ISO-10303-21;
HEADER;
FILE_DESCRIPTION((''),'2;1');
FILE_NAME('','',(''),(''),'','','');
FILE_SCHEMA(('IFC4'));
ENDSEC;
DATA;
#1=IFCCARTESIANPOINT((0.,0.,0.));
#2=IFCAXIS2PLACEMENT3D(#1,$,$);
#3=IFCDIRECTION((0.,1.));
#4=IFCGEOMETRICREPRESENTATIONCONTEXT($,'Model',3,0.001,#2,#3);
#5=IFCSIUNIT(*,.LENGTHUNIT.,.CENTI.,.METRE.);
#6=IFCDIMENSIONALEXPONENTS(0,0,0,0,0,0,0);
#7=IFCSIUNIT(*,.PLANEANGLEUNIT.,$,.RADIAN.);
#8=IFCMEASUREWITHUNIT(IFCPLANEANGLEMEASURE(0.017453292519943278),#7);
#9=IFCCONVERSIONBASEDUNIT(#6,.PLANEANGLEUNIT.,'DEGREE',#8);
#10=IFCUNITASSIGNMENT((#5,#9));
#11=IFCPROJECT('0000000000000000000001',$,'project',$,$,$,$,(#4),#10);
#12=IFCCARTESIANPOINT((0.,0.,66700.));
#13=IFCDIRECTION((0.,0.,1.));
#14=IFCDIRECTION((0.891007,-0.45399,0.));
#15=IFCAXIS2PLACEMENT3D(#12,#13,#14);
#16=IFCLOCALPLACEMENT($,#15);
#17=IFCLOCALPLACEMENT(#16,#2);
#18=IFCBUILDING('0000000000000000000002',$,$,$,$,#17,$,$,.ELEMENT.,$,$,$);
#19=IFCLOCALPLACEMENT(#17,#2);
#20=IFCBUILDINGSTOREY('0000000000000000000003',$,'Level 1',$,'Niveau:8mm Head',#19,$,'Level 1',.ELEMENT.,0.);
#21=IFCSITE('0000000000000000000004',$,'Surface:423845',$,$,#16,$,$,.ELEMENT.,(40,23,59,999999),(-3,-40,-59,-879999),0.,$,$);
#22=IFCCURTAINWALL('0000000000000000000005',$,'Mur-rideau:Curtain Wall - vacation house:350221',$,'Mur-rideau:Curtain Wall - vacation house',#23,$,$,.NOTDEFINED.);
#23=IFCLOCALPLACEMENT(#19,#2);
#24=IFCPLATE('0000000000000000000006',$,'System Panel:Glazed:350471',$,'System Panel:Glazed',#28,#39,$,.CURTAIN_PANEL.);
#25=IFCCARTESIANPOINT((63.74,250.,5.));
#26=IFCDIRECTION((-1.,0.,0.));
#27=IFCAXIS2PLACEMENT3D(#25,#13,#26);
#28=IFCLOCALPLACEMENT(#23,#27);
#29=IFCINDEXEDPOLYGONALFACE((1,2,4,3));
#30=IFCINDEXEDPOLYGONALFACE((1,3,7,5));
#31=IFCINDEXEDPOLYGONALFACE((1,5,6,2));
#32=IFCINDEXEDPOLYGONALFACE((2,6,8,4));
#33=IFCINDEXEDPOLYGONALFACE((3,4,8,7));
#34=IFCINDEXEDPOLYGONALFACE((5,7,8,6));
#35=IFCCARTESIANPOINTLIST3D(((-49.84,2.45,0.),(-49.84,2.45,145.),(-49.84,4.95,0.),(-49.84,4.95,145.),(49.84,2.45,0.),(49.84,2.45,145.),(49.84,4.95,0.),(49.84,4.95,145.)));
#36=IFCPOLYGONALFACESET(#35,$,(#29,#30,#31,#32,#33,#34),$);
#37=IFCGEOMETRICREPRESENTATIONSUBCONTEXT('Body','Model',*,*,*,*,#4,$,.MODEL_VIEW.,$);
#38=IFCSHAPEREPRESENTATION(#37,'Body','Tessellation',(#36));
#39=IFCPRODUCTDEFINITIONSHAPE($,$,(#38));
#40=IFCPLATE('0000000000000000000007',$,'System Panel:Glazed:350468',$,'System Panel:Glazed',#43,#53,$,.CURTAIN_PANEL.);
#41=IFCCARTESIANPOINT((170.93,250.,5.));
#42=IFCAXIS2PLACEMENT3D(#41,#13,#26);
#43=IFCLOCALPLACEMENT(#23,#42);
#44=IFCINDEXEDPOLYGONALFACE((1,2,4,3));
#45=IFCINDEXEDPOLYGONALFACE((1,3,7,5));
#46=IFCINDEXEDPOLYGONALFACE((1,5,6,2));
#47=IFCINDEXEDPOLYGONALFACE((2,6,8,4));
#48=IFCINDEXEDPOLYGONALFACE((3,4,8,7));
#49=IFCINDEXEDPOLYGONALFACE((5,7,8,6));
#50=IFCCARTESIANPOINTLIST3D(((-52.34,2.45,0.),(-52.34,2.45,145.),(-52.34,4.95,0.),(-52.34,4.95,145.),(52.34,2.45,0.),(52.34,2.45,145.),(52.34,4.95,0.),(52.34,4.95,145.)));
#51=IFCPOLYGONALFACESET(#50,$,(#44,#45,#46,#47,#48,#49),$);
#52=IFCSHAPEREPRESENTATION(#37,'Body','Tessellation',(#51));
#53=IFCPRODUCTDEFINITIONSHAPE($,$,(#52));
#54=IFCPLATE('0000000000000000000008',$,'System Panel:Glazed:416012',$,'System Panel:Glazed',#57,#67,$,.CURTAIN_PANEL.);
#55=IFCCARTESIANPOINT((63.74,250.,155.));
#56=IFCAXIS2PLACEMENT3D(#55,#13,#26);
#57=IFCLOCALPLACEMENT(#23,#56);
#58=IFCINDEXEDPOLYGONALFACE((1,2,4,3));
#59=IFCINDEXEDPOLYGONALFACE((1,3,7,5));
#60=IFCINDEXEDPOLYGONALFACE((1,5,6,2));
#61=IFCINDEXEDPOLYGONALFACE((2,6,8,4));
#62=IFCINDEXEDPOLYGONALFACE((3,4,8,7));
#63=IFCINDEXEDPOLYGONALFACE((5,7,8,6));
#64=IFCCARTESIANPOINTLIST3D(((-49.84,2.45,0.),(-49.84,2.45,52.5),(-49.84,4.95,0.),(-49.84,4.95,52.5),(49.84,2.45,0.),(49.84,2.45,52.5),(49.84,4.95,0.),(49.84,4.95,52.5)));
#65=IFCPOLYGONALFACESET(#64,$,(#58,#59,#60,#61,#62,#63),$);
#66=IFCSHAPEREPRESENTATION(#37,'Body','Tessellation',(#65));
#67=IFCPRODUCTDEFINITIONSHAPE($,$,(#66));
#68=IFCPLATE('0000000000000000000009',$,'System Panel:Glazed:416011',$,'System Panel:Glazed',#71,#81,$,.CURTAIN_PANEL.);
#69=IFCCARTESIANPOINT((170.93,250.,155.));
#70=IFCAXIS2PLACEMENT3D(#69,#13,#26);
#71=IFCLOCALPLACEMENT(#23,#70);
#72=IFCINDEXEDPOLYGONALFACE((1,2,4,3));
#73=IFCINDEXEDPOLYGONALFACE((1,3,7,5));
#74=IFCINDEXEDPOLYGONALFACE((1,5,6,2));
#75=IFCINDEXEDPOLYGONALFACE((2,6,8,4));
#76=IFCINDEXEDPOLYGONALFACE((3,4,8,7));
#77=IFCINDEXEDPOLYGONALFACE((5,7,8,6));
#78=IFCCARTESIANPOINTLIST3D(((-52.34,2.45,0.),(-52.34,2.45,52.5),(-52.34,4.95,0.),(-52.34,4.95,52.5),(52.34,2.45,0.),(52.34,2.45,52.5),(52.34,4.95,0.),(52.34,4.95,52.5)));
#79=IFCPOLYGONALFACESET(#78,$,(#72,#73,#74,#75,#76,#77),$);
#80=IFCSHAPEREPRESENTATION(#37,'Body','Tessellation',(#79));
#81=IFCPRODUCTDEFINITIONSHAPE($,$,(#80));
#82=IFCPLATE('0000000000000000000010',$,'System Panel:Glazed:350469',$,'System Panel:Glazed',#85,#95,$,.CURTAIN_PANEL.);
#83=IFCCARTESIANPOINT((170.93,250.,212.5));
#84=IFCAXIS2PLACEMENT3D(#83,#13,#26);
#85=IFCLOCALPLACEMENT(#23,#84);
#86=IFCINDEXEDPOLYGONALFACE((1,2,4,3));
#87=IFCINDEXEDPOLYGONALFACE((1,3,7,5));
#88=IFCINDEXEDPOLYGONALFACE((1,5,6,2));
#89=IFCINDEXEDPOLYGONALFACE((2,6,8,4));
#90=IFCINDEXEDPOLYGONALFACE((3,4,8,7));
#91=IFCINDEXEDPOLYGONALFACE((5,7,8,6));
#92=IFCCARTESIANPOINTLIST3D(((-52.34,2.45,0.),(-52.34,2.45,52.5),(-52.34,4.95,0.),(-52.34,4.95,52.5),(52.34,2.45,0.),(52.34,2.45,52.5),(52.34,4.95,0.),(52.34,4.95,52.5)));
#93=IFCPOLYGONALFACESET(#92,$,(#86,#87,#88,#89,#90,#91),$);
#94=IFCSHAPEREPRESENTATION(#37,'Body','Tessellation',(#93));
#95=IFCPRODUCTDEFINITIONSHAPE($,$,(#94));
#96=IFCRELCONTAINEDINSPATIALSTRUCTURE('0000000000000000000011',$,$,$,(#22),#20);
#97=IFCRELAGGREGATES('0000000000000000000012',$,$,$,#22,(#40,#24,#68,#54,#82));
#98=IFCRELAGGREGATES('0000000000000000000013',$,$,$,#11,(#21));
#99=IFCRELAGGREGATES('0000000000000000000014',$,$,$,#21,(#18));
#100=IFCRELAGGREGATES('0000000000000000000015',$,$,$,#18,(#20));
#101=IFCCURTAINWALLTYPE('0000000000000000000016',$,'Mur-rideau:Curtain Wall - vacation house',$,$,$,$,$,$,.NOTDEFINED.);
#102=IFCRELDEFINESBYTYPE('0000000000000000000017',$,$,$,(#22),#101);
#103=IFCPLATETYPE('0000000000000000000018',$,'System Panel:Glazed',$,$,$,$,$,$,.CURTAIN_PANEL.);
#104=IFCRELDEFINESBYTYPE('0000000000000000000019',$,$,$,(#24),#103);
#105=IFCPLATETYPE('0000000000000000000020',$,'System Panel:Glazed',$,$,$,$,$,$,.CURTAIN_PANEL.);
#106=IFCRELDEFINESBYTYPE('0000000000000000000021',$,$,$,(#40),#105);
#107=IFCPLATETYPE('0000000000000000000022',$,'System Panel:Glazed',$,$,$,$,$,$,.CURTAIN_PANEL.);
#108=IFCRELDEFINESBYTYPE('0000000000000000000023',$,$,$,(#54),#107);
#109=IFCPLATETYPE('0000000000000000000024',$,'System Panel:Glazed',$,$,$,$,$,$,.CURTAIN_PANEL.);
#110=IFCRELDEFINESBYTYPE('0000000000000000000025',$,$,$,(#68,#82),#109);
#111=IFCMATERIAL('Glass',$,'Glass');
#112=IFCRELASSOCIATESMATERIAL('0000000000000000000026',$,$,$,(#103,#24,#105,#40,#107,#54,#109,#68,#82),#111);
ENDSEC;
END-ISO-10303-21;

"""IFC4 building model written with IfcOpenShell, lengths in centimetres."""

from ifc_helpers import new_model, entity, si_unit, converted_unit, direction, frame, origin, origin_2d_with_axis, place, context, subcontext, project, spatial, rectangle, extrude, source, transform, mapped, material, type_object, type_shapes, element, aggregate, save


model = new_model("IFC4")

# Units and contexts
model_context = context("Model", 3, precision=0.001, world=origin(), true_north=direction((0.0, 1.0)))
body_context = subcontext(model_context, "Body", "Model", "MODEL_VIEW")
ifc_project = project(units=[si_unit("LENGTHUNIT", "METRE", prefix="CENTI"), converted_unit("PLANEANGLEUNIT", "DEGREE", entity("IfcPlaneAngleMeasure", 0.017453292519943278), si_unit("PLANEANGLEUNIT", "RADIAN"), dimensions=[0, 0, 0, 0, 0, 0, 0])], contexts=[model_context])

# Site, building, storey
site_placement = place(None, frame((0.0, 0.0, 66700.0), z_axis=(0.0, 0.0, 1.0), x_axis=(0.891007, -0.45399, 0.0)))
site = spatial("IfcSite", under=ifc_project, at=site_placement, Name="Surface:423845", CompositionType="ELEMENT", RefLatitude=(40, 23, 59, 999999), RefLongitude=(-3, -40, -59, -879999), RefElevation=0.0)
building_placement = place(site_placement, origin())
building = spatial("IfcBuilding", under=site, at=building_placement, CompositionType="ELEMENT")
storey_placement = place(building_placement, origin())
storey = spatial("IfcBuildingStorey", under=building, at=storey_placement, Name="Level 1", ObjectType="Niveau:8mm Head", LongName="Level 1", CompositionType="ELEMENT", Elevation=0.0)

# Curtain wall, plates
curtain_wall_type = type_object("IfcCurtainWallType", Name="Mur-rideau:Curtain Wall - vacation house", PredefinedType="NOTDEFINED")
curtain_wall_placement = place(storey_placement, origin())
curtain_wall = element("IfcCurtainWall", 1, at=curtain_wall_placement, inside=storey, type_object=curtain_wall_type, Name="Mur-rideau:Curtain Wall - vacation house:350221", ObjectType="Mur-rideau:Curtain Wall - vacation house", PredefinedType="NOTDEFINED")
ifc_material_1 = material(Name="Glass", Category="Glass")
plate_type_1 = type_object("IfcPlateType", Name="System Panel:Glazed", PredefinedType="CURTAIN_PANEL", material=ifc_material_1)
shared_shape_1 = source(origin(), body_context, "Body", "SweptSolid", [
    extrude(rectangle(XDim=2.5, YDim=99.69, at=origin_2d_with_axis()), frame((0.0, 3.7, 0.0), z_axis=(0.0, 0.0, 1.0), x_axis=(0.0, 1.0, 0.0)), (0.0, 0.0, 1.0), 145.0),
])
type_shapes(plate_type_1, [shared_shape_1])
plate_1_placement = place(curtain_wall_placement, frame((63.74, 250.0, 5.0), z_axis=(0.0, 0.0, 1.0), x_axis=(-1.0, 0.0, 0.0)))
plate_1 = element("IfcPlate", 2, at=plate_1_placement, type_object=plate_type_1, material=ifc_material_1, Name="System Panel:Glazed:350471", ObjectType="System Panel:Glazed", PredefinedType="CURTAIN_PANEL", context=body_context, shape_type="MappedRepresentation", body=[
    mapped(shared_shape_1, transform((0.0, 0.0, 0.0), scale=1.0)),
])
plate_type_2 = type_object("IfcPlateType", Name="System Panel:Glazed", PredefinedType="CURTAIN_PANEL", material=ifc_material_1)
shared_shape_2 = source(origin(), body_context, "Body", "SweptSolid", [
    extrude(rectangle(XDim=2.5, YDim=104.69, at=origin_2d_with_axis()), frame((0.0, 3.7, 0.0), z_axis=(0.0, 0.0, 1.0), x_axis=(0.0, 1.0, 0.0)), (0.0, 0.0, 1.0), 145.0),
])
type_shapes(plate_type_2, [shared_shape_2])
plate_2_placement = place(curtain_wall_placement, frame((170.93, 250.0, 5.0), z_axis=(0.0, 0.0, 1.0), x_axis=(-1.0, 0.0, 0.0)))
plate_2 = element("IfcPlate", 3, at=plate_2_placement, type_object=plate_type_2, material=ifc_material_1, Name="System Panel:Glazed:350468", ObjectType="System Panel:Glazed", PredefinedType="CURTAIN_PANEL", context=body_context, shape_type="MappedRepresentation", body=[
    mapped(shared_shape_2, transform((0.0, 0.0, 0.0), scale=1.0)),
])
plate_type_3 = type_object("IfcPlateType", Name="System Panel:Glazed", PredefinedType="CURTAIN_PANEL", material=ifc_material_1)
shared_shape_3 = source(origin(), body_context, "Body", "SweptSolid", [
    extrude(rectangle(XDim=2.5, YDim=99.69, at=origin_2d_with_axis()), frame((0.0, 3.7, 0.0), z_axis=(0.0, 0.0, 1.0), x_axis=(0.0, 1.0, 0.0)), (0.0, 0.0, 1.0), 52.5),
])
type_shapes(plate_type_3, [shared_shape_3])
plate_3_placement = place(curtain_wall_placement, frame((63.74, 250.0, 155.0), z_axis=(0.0, 0.0, 1.0), x_axis=(-1.0, 0.0, 0.0)))
plate_3 = element("IfcPlate", 4, at=plate_3_placement, type_object=plate_type_3, material=ifc_material_1, Name="System Panel:Glazed:416012", ObjectType="System Panel:Glazed", PredefinedType="CURTAIN_PANEL", context=body_context, shape_type="MappedRepresentation", body=[
    mapped(shared_shape_3, transform((0.0, 0.0, 0.0), scale=1.0)),
])
plate_type_4 = type_object("IfcPlateType", Name="System Panel:Glazed", PredefinedType="CURTAIN_PANEL", material=ifc_material_1)
shared_shape_4 = source(origin(), body_context, "Body", "SweptSolid", [
    extrude(rectangle(XDim=2.5, YDim=104.69, at=origin_2d_with_axis()), frame((0.0, 3.7, 0.0), z_axis=(0.0, 0.0, 1.0), x_axis=(0.0, 1.0, 0.0)), (0.0, 0.0, 1.0), 52.5),
])
type_shapes(plate_type_4, [shared_shape_4])
plate_4_placement = place(curtain_wall_placement, frame((170.93, 250.0, 155.0), z_axis=(0.0, 0.0, 1.0), x_axis=(-1.0, 0.0, 0.0)))
plate_4 = element("IfcPlate", 5, at=plate_4_placement, type_object=plate_type_4, material=ifc_material_1, Name="System Panel:Glazed:416011", ObjectType="System Panel:Glazed", PredefinedType="CURTAIN_PANEL", context=body_context, shape_type="MappedRepresentation", body=[
    mapped(shared_shape_4, transform((0.0, 0.0, 0.0), scale=1.0)),
])
plate_5_placement = place(curtain_wall_placement, frame((170.93, 250.0, 212.5), z_axis=(0.0, 0.0, 1.0), x_axis=(-1.0, 0.0, 0.0)))
plate_5 = element("IfcPlate", 6, at=plate_5_placement, type_object=plate_type_4, material=ifc_material_1, Name="System Panel:Glazed:350469", ObjectType="System Panel:Glazed", PredefinedType="CURTAIN_PANEL", context=body_context, shape_type="MappedRepresentation", body=[
    mapped(shared_shape_4, transform((0.0, 0.0, 0.0), scale=1.0)),
])
aggregate(curtain_wall, [plate_2, plate_1, plate_4, plate_3, plate_5])

save(model, "model.ifc")
